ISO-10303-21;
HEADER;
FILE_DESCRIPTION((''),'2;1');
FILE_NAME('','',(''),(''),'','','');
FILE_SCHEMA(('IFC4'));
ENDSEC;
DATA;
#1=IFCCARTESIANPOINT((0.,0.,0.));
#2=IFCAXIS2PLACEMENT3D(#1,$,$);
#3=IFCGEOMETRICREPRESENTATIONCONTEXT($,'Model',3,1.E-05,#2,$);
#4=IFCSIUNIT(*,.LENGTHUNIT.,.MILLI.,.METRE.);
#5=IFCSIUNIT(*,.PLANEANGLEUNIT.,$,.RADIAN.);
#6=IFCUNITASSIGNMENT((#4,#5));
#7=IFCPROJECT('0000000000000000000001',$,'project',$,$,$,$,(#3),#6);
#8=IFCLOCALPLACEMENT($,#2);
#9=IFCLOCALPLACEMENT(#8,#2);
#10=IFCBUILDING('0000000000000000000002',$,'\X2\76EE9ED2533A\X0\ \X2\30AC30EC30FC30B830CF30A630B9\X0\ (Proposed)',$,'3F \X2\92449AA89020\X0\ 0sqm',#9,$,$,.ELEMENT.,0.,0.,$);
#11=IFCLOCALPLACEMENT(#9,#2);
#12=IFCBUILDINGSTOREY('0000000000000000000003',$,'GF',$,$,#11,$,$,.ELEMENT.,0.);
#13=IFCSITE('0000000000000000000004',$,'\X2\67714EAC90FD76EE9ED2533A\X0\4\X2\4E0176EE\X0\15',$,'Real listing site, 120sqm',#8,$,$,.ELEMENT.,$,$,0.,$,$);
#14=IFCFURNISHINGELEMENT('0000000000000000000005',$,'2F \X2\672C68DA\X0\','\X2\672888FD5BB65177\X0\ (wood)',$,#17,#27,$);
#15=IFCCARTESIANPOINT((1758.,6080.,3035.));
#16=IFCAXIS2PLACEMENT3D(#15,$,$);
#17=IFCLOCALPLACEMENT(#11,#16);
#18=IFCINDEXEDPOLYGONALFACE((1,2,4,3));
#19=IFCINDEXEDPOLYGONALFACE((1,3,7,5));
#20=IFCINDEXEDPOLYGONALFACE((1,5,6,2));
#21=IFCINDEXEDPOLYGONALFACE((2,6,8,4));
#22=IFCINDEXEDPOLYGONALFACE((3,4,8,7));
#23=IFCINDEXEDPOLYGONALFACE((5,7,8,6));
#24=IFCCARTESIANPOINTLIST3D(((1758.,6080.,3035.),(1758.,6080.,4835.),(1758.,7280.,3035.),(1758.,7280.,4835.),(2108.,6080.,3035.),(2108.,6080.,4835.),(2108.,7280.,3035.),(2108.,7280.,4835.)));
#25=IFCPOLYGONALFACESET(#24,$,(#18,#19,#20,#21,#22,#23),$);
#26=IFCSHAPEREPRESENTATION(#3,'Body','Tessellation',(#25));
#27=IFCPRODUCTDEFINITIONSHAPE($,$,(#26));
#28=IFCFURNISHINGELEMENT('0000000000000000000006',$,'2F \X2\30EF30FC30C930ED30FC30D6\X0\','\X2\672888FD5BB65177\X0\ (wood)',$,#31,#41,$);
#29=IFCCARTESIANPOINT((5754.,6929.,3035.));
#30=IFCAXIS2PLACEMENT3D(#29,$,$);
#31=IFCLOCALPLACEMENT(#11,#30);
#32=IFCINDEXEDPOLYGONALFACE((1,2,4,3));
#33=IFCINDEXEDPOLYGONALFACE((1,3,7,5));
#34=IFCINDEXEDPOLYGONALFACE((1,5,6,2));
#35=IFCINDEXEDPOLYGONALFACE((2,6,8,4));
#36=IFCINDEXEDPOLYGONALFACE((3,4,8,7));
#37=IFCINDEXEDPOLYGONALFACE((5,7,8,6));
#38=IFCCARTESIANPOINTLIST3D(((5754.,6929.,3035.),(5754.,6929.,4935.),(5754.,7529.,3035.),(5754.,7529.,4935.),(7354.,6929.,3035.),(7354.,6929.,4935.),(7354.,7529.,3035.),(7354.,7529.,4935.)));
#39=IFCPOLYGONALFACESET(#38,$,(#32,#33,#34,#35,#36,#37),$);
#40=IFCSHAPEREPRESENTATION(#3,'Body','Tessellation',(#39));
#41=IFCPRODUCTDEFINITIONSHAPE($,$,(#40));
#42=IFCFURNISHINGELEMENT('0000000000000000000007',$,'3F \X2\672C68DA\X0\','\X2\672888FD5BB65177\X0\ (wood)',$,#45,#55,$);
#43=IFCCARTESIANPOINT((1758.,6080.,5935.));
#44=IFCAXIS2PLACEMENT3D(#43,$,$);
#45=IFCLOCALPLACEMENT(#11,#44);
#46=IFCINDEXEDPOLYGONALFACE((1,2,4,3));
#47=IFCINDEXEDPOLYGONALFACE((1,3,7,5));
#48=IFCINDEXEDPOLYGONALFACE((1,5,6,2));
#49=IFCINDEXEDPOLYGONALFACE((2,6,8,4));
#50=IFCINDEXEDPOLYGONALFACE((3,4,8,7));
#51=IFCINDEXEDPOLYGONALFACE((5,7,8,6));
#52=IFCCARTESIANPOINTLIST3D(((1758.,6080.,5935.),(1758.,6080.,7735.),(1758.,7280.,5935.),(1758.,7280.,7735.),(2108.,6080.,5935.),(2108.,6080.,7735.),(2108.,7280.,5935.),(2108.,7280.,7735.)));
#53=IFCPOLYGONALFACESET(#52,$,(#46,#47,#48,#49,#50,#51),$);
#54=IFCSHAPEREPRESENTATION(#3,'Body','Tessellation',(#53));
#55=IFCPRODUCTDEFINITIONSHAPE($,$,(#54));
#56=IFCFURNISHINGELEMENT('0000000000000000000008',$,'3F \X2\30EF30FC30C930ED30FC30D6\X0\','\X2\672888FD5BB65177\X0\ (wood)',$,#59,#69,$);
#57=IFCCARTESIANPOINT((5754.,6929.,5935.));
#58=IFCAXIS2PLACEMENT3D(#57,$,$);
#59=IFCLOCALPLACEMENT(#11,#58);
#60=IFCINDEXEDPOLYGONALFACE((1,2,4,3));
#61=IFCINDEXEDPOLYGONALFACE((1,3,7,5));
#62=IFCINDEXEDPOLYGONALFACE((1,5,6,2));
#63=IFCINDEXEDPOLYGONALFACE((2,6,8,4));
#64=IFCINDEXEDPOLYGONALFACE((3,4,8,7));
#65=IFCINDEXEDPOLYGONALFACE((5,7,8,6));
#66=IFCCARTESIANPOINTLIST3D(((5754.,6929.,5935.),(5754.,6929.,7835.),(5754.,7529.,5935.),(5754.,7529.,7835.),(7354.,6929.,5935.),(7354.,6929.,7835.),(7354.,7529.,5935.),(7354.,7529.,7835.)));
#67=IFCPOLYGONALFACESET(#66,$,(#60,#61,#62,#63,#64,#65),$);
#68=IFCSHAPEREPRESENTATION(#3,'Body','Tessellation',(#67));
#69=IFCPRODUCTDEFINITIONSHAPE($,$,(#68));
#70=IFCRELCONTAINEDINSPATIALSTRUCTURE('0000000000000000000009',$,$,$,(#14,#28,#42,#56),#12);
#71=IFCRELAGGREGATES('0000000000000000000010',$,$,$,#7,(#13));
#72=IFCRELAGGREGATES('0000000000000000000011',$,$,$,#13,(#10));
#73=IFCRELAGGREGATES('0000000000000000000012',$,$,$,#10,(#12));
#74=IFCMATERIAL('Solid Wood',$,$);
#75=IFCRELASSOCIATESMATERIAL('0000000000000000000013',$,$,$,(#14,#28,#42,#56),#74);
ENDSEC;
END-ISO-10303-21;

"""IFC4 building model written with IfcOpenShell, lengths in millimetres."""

from ifc_helpers import new_model, si_unit, frame, frame_2d, origin, place, context, project, spatial, rectangle, extrude, material, element, save


model = new_model("IFC4")

# Units and contexts
model_context = context("Model", 3, precision=1e-05, world=origin())
ifc_project = project(units=[si_unit("LENGTHUNIT", "METRE", prefix="MILLI"), si_unit("PLANEANGLEUNIT", "RADIAN")], contexts=[model_context])

# Site, building, storey
site_placement = place(None, origin())
site = spatial("IfcSite", under=ifc_project, at=site_placement, Name="東京都目黒区4丁目15", ObjectType="Real listing site, 120sqm", CompositionType="ELEMENT", RefElevation=0.0)
building_placement = place(site_placement, origin())
building = spatial("IfcBuilding", under=site, at=building_placement, Name="目黒区 ガレージハウス (Proposed)", ObjectType="3F 鉄骨造 0sqm", CompositionType="ELEMENT", ElevationOfRefHeight=0.0, ElevationOfTerrain=0.0)
storey_placement = place(building_placement, origin())
storey = spatial("IfcBuildingStorey", under=building, at=storey_placement, Name="GF", CompositionType="ELEMENT", Elevation=0.0)

# Shared definitions
ifc_material_1 = material(Name="Solid Wood")

# Furnishing elements
furnishing_1_placement = place(storey_placement, frame((1758.0, 6080.0, 3035.0)))
element("IfcFurnishingElement", 1, at=furnishing_1_placement, inside=storey, material=ifc_material_1, Name="2F 本棚", Description="木製家具 (wood)", context=model_context, shape_type="SweptSolid", body=[
    extrude(rectangle(XDim=350.0, YDim=1200.0, at=frame_2d((175.0, 600.0))), frame((1758.0, 6080.0, 3035.0)), (0.0, 0.0, 1.0), 1800.0),
])
furnishing_2_placement = place(storey_placement, frame((5754.0, 6929.0, 3035.0)))
element("IfcFurnishingElement", 2, at=furnishing_2_placement, inside=storey, material=ifc_material_1, Name="2F ワードローブ", Description="木製家具 (wood)", context=model_context, shape_type="SweptSolid", body=[
    extrude(rectangle(XDim=1600.0, YDim=600.0, at=frame_2d((800.0, 300.0))), frame((5754.0, 6929.0, 3035.0)), (0.0, 0.0, 1.0), 1900.0),
])
furnishing_3_placement = place(storey_placement, frame((1758.0, 6080.0, 5935.0)))
element("IfcFurnishingElement", 3, at=furnishing_3_placement, inside=storey, material=ifc_material_1, Name="3F 本棚", Description="木製家具 (wood)", context=model_context, shape_type="SweptSolid", body=[
    extrude(rectangle(XDim=350.0, YDim=1200.0, at=frame_2d((175.0, 600.0))), frame((1758.0, 6080.0, 5935.0)), (0.0, 0.0, 1.0), 1800.0),
])
furnishing_4_placement = place(storey_placement, frame((5754.0, 6929.0, 5935.0)))
element("IfcFurnishingElement", 4, at=furnishing_4_placement, inside=storey, material=ifc_material_1, Name="3F ワードローブ", Description="木製家具 (wood)", context=model_context, shape_type="SweptSolid", body=[
    extrude(rectangle(XDim=1600.0, YDim=600.0, at=frame_2d((800.0, 300.0))), frame((5754.0, 6929.0, 5935.0)), (0.0, 0.0, 1.0), 1900.0),
])

save(model, "model.ifc")
